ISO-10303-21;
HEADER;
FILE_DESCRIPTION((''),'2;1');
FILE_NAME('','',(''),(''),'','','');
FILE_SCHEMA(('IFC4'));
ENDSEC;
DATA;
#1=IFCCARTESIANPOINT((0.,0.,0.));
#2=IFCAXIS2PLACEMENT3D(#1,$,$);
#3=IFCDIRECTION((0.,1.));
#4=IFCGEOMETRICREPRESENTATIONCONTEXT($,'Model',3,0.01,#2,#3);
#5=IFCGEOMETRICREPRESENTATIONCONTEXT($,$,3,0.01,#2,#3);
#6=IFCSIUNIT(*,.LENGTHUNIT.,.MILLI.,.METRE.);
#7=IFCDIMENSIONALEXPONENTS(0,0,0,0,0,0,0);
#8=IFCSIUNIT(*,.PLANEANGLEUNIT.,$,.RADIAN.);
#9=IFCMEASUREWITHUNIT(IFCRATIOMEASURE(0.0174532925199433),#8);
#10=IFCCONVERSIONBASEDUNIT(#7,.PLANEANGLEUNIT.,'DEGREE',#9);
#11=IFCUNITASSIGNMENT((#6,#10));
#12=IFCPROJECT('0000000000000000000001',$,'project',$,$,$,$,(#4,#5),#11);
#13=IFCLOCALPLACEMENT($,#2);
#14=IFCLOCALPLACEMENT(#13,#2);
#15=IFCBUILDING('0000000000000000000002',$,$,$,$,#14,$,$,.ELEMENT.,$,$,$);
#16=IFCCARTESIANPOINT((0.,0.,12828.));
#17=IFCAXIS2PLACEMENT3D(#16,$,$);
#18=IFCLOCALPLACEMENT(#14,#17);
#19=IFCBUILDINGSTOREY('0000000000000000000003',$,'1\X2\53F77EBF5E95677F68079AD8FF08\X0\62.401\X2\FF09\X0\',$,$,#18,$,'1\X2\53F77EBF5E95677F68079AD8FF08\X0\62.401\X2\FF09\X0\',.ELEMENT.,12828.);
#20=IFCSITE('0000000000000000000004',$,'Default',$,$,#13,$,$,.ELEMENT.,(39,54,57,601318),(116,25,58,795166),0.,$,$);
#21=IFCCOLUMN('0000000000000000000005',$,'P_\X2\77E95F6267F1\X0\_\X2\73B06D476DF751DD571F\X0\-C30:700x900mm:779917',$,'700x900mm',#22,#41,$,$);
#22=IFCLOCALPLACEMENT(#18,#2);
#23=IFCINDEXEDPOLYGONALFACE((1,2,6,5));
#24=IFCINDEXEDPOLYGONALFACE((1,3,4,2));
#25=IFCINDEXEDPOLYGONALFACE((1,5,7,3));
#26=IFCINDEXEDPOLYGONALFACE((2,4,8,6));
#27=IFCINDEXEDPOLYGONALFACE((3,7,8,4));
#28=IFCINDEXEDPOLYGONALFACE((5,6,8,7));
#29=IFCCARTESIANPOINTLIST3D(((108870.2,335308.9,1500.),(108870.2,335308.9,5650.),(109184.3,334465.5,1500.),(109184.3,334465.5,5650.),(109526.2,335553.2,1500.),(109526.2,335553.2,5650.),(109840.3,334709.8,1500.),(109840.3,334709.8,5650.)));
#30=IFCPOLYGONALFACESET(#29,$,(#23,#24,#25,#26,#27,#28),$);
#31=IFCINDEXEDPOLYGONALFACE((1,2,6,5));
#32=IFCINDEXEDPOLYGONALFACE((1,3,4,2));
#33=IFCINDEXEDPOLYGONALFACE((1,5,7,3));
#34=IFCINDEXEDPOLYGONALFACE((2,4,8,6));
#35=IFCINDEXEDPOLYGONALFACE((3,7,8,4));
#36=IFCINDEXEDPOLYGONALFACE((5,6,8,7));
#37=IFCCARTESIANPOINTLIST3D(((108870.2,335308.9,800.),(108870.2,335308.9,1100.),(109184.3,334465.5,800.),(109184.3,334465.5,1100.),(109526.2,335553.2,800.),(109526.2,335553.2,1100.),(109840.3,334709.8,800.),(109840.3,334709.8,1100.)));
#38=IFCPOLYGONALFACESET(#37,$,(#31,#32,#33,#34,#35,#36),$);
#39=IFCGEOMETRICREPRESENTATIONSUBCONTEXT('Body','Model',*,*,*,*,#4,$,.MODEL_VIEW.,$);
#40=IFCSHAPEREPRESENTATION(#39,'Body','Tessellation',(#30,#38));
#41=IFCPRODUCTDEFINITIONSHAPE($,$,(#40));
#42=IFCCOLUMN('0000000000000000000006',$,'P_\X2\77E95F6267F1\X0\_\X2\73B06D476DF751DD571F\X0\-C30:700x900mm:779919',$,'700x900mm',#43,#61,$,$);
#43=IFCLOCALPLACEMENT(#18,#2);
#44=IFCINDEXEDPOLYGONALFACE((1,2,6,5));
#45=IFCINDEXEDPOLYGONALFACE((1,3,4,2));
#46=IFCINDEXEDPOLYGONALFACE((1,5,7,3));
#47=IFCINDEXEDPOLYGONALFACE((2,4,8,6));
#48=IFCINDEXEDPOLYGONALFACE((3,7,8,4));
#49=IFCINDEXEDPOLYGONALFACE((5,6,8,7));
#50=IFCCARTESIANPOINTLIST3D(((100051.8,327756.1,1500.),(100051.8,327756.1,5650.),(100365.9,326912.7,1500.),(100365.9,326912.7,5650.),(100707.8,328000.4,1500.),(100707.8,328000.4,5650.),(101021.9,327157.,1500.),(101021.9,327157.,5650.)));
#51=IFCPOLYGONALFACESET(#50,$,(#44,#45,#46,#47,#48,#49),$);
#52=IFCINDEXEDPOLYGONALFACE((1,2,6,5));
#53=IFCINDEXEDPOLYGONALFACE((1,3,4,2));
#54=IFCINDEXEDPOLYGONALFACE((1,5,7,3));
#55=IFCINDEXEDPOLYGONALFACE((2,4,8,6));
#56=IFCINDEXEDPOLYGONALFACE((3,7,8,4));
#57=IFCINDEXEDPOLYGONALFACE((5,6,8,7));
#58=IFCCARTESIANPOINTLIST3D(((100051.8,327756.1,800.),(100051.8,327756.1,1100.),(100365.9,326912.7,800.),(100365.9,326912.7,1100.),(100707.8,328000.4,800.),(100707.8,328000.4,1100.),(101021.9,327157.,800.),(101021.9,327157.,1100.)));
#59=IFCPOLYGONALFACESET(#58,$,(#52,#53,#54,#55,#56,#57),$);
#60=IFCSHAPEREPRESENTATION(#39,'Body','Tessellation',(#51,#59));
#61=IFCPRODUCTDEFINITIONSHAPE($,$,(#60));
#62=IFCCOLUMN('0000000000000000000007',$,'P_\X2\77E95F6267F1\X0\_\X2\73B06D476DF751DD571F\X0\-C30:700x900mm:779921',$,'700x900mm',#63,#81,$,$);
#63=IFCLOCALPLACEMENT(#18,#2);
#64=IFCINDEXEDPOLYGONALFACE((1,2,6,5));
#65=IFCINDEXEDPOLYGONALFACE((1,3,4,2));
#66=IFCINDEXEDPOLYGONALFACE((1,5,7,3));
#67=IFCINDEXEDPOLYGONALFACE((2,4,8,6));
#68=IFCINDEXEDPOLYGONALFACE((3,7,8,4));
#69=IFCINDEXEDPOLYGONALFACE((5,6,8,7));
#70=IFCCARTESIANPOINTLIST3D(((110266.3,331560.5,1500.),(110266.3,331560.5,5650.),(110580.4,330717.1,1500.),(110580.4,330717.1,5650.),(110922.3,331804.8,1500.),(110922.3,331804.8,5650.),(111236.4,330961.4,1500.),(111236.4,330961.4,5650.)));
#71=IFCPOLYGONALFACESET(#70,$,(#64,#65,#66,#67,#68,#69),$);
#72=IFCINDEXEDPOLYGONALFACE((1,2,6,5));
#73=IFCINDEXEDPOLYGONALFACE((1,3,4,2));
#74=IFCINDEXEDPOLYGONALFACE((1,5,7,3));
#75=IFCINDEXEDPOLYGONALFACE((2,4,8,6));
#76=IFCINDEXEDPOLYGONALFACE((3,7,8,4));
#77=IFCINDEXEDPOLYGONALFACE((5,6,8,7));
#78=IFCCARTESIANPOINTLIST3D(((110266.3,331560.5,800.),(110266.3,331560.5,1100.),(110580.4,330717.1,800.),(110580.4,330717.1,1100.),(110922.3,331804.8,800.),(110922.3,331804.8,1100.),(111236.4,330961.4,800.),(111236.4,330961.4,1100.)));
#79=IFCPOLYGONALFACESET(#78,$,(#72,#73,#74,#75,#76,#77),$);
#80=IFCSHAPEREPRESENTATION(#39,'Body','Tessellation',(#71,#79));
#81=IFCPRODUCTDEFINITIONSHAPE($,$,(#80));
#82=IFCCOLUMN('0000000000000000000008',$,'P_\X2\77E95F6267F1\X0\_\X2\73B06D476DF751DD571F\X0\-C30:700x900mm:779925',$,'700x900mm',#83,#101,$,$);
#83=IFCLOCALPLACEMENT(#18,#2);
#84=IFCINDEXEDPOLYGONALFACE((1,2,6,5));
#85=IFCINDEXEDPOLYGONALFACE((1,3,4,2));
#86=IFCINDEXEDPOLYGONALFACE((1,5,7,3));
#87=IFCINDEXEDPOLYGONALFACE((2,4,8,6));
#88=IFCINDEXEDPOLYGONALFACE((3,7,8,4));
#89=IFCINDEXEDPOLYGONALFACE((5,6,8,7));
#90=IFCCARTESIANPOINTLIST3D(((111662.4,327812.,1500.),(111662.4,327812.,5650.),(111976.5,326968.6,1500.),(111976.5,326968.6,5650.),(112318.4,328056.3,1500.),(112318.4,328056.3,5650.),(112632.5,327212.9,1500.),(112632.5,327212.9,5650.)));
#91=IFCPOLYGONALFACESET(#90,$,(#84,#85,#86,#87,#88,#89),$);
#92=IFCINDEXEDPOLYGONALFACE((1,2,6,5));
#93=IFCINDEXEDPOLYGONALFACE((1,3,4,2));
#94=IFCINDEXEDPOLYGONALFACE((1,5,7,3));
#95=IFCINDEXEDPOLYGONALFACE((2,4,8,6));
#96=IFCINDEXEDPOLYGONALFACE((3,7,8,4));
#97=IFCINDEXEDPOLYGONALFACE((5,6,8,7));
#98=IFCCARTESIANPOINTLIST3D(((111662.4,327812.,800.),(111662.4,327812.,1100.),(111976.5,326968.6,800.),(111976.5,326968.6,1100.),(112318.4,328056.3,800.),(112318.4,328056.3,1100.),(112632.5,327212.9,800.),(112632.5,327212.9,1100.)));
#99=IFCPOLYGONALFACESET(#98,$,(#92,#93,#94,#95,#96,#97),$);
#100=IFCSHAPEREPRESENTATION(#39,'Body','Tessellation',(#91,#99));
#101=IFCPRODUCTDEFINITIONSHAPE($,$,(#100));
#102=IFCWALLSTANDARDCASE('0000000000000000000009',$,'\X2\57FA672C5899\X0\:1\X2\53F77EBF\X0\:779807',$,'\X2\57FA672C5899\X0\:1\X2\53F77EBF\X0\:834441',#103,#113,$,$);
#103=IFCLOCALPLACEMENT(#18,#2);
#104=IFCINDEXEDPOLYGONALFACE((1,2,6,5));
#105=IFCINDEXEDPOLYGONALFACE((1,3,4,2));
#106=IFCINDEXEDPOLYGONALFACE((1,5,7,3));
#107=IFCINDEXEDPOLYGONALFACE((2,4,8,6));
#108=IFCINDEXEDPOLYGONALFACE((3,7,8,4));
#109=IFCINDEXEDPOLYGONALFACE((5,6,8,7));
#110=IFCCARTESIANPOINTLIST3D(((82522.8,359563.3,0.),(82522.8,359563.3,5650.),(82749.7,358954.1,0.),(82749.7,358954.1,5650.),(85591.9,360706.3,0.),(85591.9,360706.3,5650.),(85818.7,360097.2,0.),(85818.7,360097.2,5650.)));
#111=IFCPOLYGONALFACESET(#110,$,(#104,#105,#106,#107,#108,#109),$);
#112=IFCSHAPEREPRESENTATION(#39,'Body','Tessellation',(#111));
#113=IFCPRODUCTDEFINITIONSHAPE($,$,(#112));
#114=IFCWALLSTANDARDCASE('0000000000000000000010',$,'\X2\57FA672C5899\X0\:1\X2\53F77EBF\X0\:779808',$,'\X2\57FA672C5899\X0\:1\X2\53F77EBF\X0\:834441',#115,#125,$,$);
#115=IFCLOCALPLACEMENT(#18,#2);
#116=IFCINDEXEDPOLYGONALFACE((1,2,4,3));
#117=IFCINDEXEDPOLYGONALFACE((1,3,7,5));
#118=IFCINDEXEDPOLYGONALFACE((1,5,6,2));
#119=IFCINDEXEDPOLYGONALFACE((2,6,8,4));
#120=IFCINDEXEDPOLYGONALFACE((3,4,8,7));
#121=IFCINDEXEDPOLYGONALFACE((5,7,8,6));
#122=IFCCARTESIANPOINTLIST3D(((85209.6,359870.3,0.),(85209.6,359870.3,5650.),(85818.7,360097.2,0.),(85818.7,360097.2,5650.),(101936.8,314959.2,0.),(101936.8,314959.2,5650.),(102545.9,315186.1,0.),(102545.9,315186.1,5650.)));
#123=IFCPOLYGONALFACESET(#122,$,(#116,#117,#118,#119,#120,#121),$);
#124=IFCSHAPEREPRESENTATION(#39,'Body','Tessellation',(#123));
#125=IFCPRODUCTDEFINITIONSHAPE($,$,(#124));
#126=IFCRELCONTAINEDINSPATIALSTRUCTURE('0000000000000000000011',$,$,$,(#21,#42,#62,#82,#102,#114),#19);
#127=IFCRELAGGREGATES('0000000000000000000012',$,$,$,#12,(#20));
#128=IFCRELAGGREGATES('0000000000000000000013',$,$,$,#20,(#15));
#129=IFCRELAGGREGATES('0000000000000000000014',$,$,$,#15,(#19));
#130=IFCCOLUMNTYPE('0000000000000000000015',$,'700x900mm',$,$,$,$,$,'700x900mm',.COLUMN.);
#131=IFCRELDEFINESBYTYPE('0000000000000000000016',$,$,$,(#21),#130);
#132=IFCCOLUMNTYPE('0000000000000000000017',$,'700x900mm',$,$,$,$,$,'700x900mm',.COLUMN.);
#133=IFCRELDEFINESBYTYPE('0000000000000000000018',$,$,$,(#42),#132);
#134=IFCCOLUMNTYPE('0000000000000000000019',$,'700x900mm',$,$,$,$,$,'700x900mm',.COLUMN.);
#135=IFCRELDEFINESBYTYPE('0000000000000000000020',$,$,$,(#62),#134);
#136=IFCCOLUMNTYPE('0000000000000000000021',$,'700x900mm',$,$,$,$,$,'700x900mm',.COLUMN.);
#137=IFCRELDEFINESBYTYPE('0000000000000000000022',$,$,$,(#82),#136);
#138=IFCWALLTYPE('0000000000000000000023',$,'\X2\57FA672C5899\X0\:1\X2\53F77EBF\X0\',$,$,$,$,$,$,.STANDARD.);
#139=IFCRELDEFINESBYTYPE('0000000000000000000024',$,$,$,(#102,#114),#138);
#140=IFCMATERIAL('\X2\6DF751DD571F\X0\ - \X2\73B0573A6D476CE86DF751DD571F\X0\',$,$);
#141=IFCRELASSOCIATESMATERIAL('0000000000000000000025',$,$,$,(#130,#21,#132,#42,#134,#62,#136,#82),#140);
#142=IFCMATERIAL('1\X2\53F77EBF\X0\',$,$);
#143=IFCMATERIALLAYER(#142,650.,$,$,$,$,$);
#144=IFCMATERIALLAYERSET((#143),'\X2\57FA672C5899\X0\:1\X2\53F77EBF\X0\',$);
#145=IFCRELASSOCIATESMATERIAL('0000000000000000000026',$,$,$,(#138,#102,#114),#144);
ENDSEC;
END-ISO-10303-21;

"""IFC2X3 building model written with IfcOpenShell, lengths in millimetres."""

from ifc_helpers import new_model, entity, si_unit, converted_unit, direction, frame, frame_2d, origin, origin_2d_with_axis, place, context, subcontext, project, spatial, polyline, rectangle, extrude, clip, bounded_halfspace, source, transform, mapped, material, layer, layer_set, layer_usage, type_object, type_shapes, element, save


model = new_model("IFC2X3")

# Units and contexts
model_context = context("Model", 3, precision=0.01, world=origin(), true_north=direction((0.0, 1.0)))
context_of_model = context(None, 3, precision=0.01, world=origin(), true_north=direction((0.0, 1.0)))
body_context = subcontext(model_context, "Body", "Model", "MODEL_VIEW")
ifc_project = project(units=[si_unit("LENGTHUNIT", "METRE", prefix="MILLI"), converted_unit("PLANEANGLEUNIT", "DEGREE", entity("IfcRatioMeasure", 0.0174532925199433), si_unit("PLANEANGLEUNIT", "RADIAN"), dimensions=[0, 0, 0, 0, 0, 0, 0])], contexts=[model_context, context_of_model])

# Site, building, storey
site_placement = place(None, origin())
site = spatial("IfcSite", under=ifc_project, at=site_placement, Name="Default", CompositionType="ELEMENT", RefLatitude=(39, 54, 57, 601318), RefLongitude=(116, 25, 58, 795166), RefElevation=0.0)
building_placement = place(site_placement, origin())
building = spatial("IfcBuilding", under=site, at=building_placement, CompositionType="ELEMENT")
storey_placement = place(building_placement, frame((0.0, 0.0, 12828.0)))
storey = spatial("IfcBuildingStorey", under=building, at=storey_placement, Name="1号线底板标高（62.401）", LongName="1号线底板标高（62.401）", CompositionType="ELEMENT", Elevation=12828.0)

# Columns
ifc_material_1 = material(Name="混凝土 - 现场浇注混凝土")
column_type_1 = type_object("IfcColumnType", Name="700x900mm", ElementType="700x900mm", PredefinedType="COLUMN", material=ifc_material_1)
shared_shape_1 = source(origin(), body_context, "Body", "SweptSolid", [
    extrude(rectangle(XDim=700.0, YDim=900.0, at=frame_2d((0.0, 0.0), x_axis=(1.0, 0.0))), frame((485.1, 543.9, 700.0), z_axis=(0.0, 0.0, 1.0), x_axis=(-0.937112, -0.349028, 0.0)), (0.0, 0.0, 1.0), 4150.0),
    extrude(rectangle(XDim=700.0, YDim=900.0, at=frame_2d((0.0, 0.0), x_axis=(1.0, 0.0))), frame((485.1, 543.9, 0.0), z_axis=(0.0, 0.0, 1.0), x_axis=(-0.937112, -0.349028, 0.0)), (0.0, 0.0, 1.0), 300.0),
])
type_shapes(column_type_1, [shared_shape_1])
column_1_placement = place(storey_placement, frame((108870.2, 334465.5, 800.0)))
element("IfcColumn", 1, at=column_1_placement, inside=storey, type_object=column_type_1, material=ifc_material_1, Name="P_矩形柱_现浇混凝土-C30:700x900mm:779917", ObjectType="700x900mm", context=body_context, shape_type="MappedRepresentation", body=[
    mapped(shared_shape_1, transform((0.0, 0.0, 0.0), scale=1.0)),
])
column_type_2 = type_object("IfcColumnType", Name="700x900mm", ElementType="700x900mm", PredefinedType="COLUMN", material=ifc_material_1)
shared_shape_2 = source(origin(), body_context, "Body", "SweptSolid", [
    extrude(rectangle(XDim=700.0, YDim=900.0, at=frame_2d((0.0, 0.0), x_axis=(1.0, 0.0))), frame((485.1, 543.9, 700.0), z_axis=(0.0, 0.0, 1.0), x_axis=(-0.937112, -0.349028, 0.0)), (0.0, 0.0, 1.0), 4150.0),
    extrude(rectangle(XDim=700.0, YDim=900.0, at=frame_2d((0.0, 0.0), x_axis=(1.0, 0.0))), frame((485.1, 543.9, 0.0), z_axis=(0.0, 0.0, 1.0), x_axis=(-0.937112, -0.349028, 0.0)), (0.0, 0.0, 1.0), 300.0),
])
type_shapes(column_type_2, [shared_shape_2])
column_2_placement = place(storey_placement, frame((100051.8, 326912.7, 800.0)))
element("IfcColumn", 2, at=column_2_placement, inside=storey, type_object=column_type_2, material=ifc_material_1, Name="P_矩形柱_现浇混凝土-C30:700x900mm:779919", ObjectType="700x900mm", context=body_context, shape_type="MappedRepresentation", body=[
    mapped(shared_shape_2, transform((0.0, 0.0, 0.0), scale=1.0)),
])
column_type_3 = type_object("IfcColumnType", Name="700x900mm", ElementType="700x900mm", PredefinedType="COLUMN", material=ifc_material_1)
shared_shape_3 = source(origin(), body_context, "Body", "SweptSolid", [
    extrude(rectangle(XDim=700.0, YDim=900.0, at=frame_2d((0.0, 0.0), x_axis=(1.0, 0.0))), frame((485.1, 543.9, 700.0), z_axis=(0.0, 0.0, 1.0), x_axis=(-0.937112, -0.349028, 0.0)), (0.0, 0.0, 1.0), 4150.0),
    extrude(rectangle(XDim=700.0, YDim=900.0, at=frame_2d((0.0, 0.0), x_axis=(1.0, 0.0))), frame((485.1, 543.9, 0.0), z_axis=(0.0, 0.0, 1.0), x_axis=(-0.937112, -0.349028, 0.0)), (0.0, 0.0, 1.0), 300.0),
])
type_shapes(column_type_3, [shared_shape_3])
column_3_placement = place(storey_placement, frame((110266.3, 330717.1, 800.0)))
element("IfcColumn", 3, at=column_3_placement, inside=storey, type_object=column_type_3, material=ifc_material_1, Name="P_矩形柱_现浇混凝土-C30:700x900mm:779921", ObjectType="700x900mm", context=body_context, shape_type="MappedRepresentation", body=[
    mapped(shared_shape_3, transform((0.0, 0.0, 0.0), scale=1.0)),
])
column_type_4 = type_object("IfcColumnType", Name="700x900mm", ElementType="700x900mm", PredefinedType="COLUMN", material=ifc_material_1)
shared_shape_4 = source(origin(), body_context, "Body", "SweptSolid", [
    extrude(rectangle(XDim=700.0, YDim=900.0, at=origin_2d_with_axis()), frame((485.1, 543.9, 700.0), z_axis=(0.0, 0.0, 1.0), x_axis=(-0.937112, -0.349028, 0.0)), (0.0, 0.0, 1.0), 4150.0),
    extrude(rectangle(XDim=700.0, YDim=900.0, at=origin_2d_with_axis()), frame((485.1, 543.9, 0.0), z_axis=(0.0, 0.0, 1.0), x_axis=(-0.937112, -0.349028, 0.0)), (0.0, 0.0, 1.0), 300.0),
])
type_shapes(column_type_4, [shared_shape_4])
column_4_placement = place(storey_placement, frame((111662.4, 326968.6, 800.0)))
element("IfcColumn", 4, at=column_4_placement, inside=storey, type_object=column_type_4, material=ifc_material_1, Name="P_矩形柱_现浇混凝土-C30:700x900mm:779925", ObjectType="700x900mm", context=body_context, shape_type="MappedRepresentation", body=[
    mapped(shared_shape_4, transform((0.0, 0.0, 0.0), scale=1.0)),
])

# Walls
ifc_material_2 = material(Name="1号线")
ifc_layer = layer(ifc_material_2, 650.0)
ifc_layer_set = layer_set([ifc_layer], Name="基本墙:1号线")
ifc_layer_usage_1 = layer_usage(ifc_layer_set, "AXIS2", "NEGATIVE", 325.0)
wall_type = type_object("IfcWallType", Name="基本墙:1号线", PredefinedType="STANDARD", material=ifc_layer_set)
wall_1_placement = place(storey_placement, frame((82636.3, 359258.7, 0.0), z_axis=(0.0, 0.0, 1.0), x_axis=(0.937112, 0.349028, 0.0)))
element("IfcWallStandardCase", 5, at=wall_1_placement, inside=storey, type_object=wall_type, material=ifc_layer_usage_1, Name="基本墙:1号线:779807", ObjectType="基本墙:1号线:834441", context=body_context, shape_type="SweptSolid", body=[
    extrude(rectangle(XDim=3275.0, YDim=650.0, at=frame_2d((1637.5, 0.0), x_axis=(-1.0, 0.0))), origin(), (0.0, 0.0, 1.0), 5650.0),
])
ifc_layer_usage_2 = layer_usage(ifc_layer_set, "AXIS2", "NEGATIVE", 325.0)
wall_2_placement = place(storey_placement, frame((85514.2, 359983.8, 0.0), z_axis=(0.0, 0.0, 1.0), x_axis=(0.349028, -0.937112, 0.0)))
element("IfcWallStandardCase", 6, at=wall_2_placement, inside=storey, type_object=wall_type, material=ifc_layer_usage_2, Name="基本墙:1号线:779808", ObjectType="基本墙:1号线:834441", context=body_context, shape_type="Clipping", body=[
    clip(extrude(rectangle(XDim=47925.0, YDim=650.0, at=frame_2d((23962.5, 0.0), x_axis=(-1.0, 0.0))), origin(), (0.0, 0.0, 1.0), 5650.0), bounded_halfspace(frame((0.0, -325.0, 5650.0), z_axis=(0.0, 0.0, -1.0), x_axis=(0.0, 1.0, 0.0)), True, frame((0.0, -325.0, 5650.0)), polyline([(0.0, 0.0), (700.0, 0.0), (46792.2, 0.0), (47275.0, 0.0), (47925.0, 0.0), (47925.0, 650.0), (43395.0, 650.0), (43295.0, 650.0), (0.0, 650.0), (0.0, 0.0)]))),
])

save(model, "model.ifc")
